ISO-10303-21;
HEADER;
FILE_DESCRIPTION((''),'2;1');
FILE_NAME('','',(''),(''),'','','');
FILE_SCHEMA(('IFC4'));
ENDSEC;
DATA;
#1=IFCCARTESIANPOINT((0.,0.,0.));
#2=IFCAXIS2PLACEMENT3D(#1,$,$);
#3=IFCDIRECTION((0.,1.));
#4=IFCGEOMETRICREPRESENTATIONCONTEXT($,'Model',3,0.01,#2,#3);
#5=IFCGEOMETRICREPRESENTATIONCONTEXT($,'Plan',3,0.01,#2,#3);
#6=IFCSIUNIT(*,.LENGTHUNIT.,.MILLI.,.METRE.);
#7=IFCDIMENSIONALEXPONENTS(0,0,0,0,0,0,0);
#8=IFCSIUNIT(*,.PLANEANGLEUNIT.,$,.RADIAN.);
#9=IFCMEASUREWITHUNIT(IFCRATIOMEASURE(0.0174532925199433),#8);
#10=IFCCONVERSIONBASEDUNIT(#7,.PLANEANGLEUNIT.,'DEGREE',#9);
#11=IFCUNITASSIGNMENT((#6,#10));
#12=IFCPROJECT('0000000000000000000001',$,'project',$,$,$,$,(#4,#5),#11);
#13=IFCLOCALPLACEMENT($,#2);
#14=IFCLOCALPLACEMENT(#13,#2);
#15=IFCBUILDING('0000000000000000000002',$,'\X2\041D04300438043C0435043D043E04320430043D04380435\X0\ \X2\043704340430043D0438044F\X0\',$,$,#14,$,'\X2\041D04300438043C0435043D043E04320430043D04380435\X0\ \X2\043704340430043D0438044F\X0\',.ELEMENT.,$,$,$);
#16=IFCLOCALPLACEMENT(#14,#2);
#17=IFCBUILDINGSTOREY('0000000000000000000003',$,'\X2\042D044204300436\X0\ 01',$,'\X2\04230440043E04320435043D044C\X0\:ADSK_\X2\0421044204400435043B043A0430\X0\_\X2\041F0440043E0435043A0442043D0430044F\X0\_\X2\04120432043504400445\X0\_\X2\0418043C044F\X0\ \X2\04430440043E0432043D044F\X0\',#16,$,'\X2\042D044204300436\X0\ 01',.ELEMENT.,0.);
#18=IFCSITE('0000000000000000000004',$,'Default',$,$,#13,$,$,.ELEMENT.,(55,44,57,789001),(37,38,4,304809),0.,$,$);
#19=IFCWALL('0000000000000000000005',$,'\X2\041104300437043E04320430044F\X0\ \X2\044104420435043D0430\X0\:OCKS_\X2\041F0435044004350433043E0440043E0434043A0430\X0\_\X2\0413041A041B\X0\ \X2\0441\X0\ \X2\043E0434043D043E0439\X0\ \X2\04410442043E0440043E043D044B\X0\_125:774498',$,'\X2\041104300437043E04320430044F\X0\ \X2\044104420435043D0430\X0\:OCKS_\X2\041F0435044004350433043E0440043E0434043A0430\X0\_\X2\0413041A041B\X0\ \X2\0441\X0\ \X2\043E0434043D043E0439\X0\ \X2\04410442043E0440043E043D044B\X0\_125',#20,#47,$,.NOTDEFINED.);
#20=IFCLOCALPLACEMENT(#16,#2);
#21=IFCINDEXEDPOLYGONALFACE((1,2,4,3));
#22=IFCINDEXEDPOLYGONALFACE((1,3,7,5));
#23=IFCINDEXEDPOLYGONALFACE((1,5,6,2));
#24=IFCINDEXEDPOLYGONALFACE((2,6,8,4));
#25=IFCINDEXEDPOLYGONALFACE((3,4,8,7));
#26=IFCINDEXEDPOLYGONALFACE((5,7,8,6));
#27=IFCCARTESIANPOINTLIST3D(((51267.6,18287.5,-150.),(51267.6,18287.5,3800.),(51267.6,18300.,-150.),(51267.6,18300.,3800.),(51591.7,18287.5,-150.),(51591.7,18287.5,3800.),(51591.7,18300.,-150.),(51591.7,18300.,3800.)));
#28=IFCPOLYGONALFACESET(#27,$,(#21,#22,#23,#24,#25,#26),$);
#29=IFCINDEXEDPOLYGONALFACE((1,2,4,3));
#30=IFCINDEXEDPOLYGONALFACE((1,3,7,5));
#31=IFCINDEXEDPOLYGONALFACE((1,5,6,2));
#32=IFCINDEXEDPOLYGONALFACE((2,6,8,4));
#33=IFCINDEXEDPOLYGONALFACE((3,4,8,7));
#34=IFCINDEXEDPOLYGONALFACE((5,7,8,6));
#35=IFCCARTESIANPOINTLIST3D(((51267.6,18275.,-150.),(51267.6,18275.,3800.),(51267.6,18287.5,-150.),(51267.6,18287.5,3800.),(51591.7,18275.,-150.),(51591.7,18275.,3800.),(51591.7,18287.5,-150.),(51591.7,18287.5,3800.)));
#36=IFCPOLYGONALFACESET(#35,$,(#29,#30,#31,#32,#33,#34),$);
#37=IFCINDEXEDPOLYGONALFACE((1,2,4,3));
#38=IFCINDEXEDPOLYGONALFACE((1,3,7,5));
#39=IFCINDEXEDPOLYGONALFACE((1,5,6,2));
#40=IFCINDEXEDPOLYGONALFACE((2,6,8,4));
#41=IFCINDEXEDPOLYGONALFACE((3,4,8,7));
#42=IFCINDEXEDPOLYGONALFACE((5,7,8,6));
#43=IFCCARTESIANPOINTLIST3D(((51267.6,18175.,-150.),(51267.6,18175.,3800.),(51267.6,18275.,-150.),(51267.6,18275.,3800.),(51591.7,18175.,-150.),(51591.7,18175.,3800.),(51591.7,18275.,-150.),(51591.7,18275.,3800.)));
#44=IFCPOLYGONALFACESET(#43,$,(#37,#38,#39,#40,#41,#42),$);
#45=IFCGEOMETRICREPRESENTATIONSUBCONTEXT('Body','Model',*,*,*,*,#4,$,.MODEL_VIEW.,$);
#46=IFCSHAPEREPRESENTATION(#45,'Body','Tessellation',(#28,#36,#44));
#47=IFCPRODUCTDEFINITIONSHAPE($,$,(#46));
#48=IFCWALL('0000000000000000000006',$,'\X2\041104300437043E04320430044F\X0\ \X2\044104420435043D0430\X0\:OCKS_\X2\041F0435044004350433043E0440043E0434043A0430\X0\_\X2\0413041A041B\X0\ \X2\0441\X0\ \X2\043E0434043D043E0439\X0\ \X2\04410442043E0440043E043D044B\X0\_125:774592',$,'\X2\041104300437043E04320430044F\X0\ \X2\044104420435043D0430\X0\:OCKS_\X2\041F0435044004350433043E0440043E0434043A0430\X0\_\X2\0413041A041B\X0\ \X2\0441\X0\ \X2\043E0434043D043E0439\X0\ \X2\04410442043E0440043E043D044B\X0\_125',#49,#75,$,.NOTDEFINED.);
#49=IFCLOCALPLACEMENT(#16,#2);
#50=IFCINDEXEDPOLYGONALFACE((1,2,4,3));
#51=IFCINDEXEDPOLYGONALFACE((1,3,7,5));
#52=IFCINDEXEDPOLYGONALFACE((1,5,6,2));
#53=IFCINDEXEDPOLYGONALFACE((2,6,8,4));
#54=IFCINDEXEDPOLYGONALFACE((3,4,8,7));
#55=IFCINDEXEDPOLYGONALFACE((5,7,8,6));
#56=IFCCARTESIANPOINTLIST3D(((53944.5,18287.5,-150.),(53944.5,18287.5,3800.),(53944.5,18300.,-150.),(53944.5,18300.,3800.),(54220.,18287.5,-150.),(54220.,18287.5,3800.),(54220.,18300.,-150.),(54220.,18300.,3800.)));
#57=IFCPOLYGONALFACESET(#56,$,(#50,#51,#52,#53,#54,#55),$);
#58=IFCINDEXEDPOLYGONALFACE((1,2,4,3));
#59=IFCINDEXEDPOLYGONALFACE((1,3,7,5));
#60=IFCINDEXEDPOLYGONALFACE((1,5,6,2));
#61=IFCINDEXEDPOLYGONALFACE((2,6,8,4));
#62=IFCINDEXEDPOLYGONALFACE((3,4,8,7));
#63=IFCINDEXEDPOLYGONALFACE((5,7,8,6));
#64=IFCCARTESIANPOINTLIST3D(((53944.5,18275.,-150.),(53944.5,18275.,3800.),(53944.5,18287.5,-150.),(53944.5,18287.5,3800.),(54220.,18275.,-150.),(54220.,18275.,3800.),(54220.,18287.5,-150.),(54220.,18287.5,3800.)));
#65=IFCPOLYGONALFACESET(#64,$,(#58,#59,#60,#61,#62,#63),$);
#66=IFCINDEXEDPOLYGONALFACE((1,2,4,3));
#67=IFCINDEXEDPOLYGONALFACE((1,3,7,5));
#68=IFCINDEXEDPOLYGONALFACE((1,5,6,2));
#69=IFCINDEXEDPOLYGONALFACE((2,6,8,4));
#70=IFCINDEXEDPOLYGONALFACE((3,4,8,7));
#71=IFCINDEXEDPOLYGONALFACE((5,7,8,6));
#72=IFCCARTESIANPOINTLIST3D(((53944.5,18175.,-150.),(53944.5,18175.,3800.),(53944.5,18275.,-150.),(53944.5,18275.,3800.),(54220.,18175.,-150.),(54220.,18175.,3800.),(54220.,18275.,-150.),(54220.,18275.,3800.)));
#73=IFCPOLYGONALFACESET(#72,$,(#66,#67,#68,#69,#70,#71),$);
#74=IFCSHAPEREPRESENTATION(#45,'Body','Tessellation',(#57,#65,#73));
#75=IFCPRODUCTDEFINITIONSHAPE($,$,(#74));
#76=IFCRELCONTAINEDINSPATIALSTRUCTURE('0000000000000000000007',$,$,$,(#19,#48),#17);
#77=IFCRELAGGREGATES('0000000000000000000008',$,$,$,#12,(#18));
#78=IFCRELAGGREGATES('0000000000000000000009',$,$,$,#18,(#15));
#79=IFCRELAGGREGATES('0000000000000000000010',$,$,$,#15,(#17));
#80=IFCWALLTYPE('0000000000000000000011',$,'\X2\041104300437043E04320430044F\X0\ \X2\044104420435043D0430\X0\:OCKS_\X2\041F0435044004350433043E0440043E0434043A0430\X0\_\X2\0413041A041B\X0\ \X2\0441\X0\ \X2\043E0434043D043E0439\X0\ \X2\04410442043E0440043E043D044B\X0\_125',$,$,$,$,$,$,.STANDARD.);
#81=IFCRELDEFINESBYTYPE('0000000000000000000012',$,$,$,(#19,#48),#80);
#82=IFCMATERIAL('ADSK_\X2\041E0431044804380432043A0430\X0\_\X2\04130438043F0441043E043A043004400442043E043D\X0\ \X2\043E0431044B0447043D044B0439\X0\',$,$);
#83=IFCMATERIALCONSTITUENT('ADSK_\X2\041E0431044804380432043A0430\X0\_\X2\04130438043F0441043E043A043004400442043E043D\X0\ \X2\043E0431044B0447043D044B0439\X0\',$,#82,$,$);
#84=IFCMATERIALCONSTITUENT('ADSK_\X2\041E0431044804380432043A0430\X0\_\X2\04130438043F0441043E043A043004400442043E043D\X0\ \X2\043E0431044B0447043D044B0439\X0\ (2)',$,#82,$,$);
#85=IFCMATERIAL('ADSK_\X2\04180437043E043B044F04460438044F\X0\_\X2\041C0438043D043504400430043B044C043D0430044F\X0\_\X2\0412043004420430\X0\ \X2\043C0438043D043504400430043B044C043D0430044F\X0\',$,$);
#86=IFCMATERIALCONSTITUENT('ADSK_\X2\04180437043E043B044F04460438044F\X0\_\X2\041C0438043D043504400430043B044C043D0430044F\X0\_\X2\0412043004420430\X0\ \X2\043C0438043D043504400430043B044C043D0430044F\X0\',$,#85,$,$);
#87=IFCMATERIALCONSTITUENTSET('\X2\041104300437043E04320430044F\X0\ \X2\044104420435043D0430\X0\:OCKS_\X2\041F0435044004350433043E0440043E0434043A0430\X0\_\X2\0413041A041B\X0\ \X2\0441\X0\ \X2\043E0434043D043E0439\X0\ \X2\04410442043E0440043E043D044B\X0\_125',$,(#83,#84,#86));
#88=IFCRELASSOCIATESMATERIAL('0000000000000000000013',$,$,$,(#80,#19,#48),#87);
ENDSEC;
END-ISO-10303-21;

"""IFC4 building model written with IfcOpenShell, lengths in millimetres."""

from ifc_helpers import new_model, entity, si_unit, converted_unit, direction, frame, origin, place, context, subcontext, project, spatial, indexed_curve, outline, extrude, material, constituent, constituent_set, type_object, element, save


model = new_model("IFC4")

# Units and contexts
model_context = context("Model", 3, precision=0.01, world=origin(), true_north=direction((0.0, 1.0)))
plan_context = context("Plan", 3, precision=0.01, world=origin(), true_north=direction((0.0, 1.0)))
body_context = subcontext(model_context, "Body", "Model", "MODEL_VIEW")
ifc_project = project(units=[si_unit("LENGTHUNIT", "METRE", prefix="MILLI"), converted_unit("PLANEANGLEUNIT", "DEGREE", entity("IfcRatioMeasure", 0.0174532925199433), si_unit("PLANEANGLEUNIT", "RADIAN"), dimensions=[0, 0, 0, 0, 0, 0, 0])], contexts=[model_context, plan_context])

# Site, building, storey
site_placement = place(None, frame((0.0, 0.0, 0.0)))
site = spatial("IfcSite", under=ifc_project, at=site_placement, Name="Default", CompositionType="ELEMENT", RefLatitude=(55, 44, 57, 789001), RefLongitude=(37, 38, 4, 304809), RefElevation=0.0)
building_placement = place(site_placement, origin())
building = spatial("IfcBuilding", under=site, at=building_placement, Name="Наименование здания", LongName="Наименование здания", CompositionType="ELEMENT")
storey_placement = place(building_placement, origin())
storey = spatial("IfcBuildingStorey", under=building, at=storey_placement, Name="Этаж 01", ObjectType="Уровень:ADSK_Стрелка_Проектная_Вверх_Имя уровня", LongName="Этаж 01", CompositionType="ELEMENT", Elevation=0.0)

# Shared definitions
ifc_material_1 = material(Name="ADSK_Обшивка_Гипсокартон обычный")
ifc_material_2 = material(Name="ADSK_Изоляция_Минеральная_Вата минеральная")

# Walls
ifc_constituent_1 = constituent(ifc_material_1, Name="ADSK_Обшивка_Гипсокартон обычный")
ifc_constituent_2 = constituent(ifc_material_1, Name="ADSK_Обшивка_Гипсокартон обычный (2)")
ifc_constituent_3 = constituent(ifc_material_2, Name="ADSK_Изоляция_Минеральная_Вата минеральная")
ifc_constituent_set_1 = constituent_set(constituents=[ifc_constituent_1, ifc_constituent_2, ifc_constituent_3], Name="Базовая стена:OCKS_Перегородка_ГКЛ с одной стороны_125")
wall_type_1 = type_object("IfcWallType", Name="Базовая стена:OCKS_Перегородка_ГКЛ с одной стороны_125", PredefinedType="STANDARD", material=ifc_constituent_set_1)
wall_1_placement = place(storey_placement, frame((51267.6, 18237.5, -150.0)))
element("IfcWall", 1, at=wall_1_placement, inside=storey, type_object=wall_type_1, material=ifc_constituent_set_1, Name="Базовая стена:OCKS_Перегородка_ГКЛ с одной стороны_125:774498", ObjectType="Базовая стена:OCKS_Перегородка_ГКЛ с одной стороны_125", PredefinedType="NOTDEFINED", context=body_context, shape_type="SweptSolid", body=[
    extrude(outline(indexed_curve([(-6.3, -162.0), (6.3, -162.0), (6.3, 162.0), (-6.2, 162.0), (-6.3, -162.0)], self_intersect=False)), frame((162.0, 56.3, 0.0), z_axis=(0.0, 0.0, 1.0), x_axis=(0.0, -1.0, 0.0)), (0.0, 0.0, 1.0), 3950.0),
    extrude(outline(indexed_curve([(-162.0, -6.2), (162.0, -6.2), (162.0, 6.3), (-162.0, 6.3), (-162.0, -6.2)], self_intersect=False)), frame((162.0, 43.7, 0.0)), (0.0, 0.0, 1.0), 3950.0),
    extrude(outline(indexed_curve([(-50.0, -162.0), (50.0, -162.0), (50.0, 162.0), (-50.0, 162.0), (-50.0, -162.0)], self_intersect=False)), frame((162.0, -12.5, 0.0), z_axis=(0.0, 0.0, 1.0), x_axis=(0.0, 1.0, 0.0)), (0.0, 0.0, 1.0), 3950.0),
])
wall_2_placement = place(storey_placement, frame((54220.0, 18237.5, -150.0), z_axis=(0.0, 0.0, 1.0), x_axis=(-1.0, 0.0, 0.0)))
element("IfcWall", 2, at=wall_2_placement, inside=storey, type_object=wall_type_1, material=ifc_constituent_set_1, Name="Базовая стена:OCKS_Перегородка_ГКЛ с одной стороны_125:774592", ObjectType="Базовая стена:OCKS_Перегородка_ГКЛ с одной стороны_125", PredefinedType="NOTDEFINED", context=body_context, shape_type="SweptSolid", body=[
    extrude(outline(indexed_curve([(-6.2, -137.7), (6.3, -137.7), (6.3, 137.7), (-6.2, 137.7), (-6.2, -137.7)], self_intersect=False)), frame((137.7, -56.3, 0.0), z_axis=(0.0, 0.0, 1.0), x_axis=(0.0, 1.0, 0.0)), (0.0, 0.0, 1.0), 3950.0),
    extrude(outline(indexed_curve([(-137.7, -6.3), (137.7, -6.3), (137.7, 6.2), (-137.7, 6.2), (-137.7, -6.3)], self_intersect=False)), frame((137.7, -43.7, 0.0)), (0.0, 0.0, 1.0), 3950.0),
    extrude(outline(indexed_curve([(-50.0, -137.7), (50.0, -137.7), (50.0, 137.7), (-50.0, 137.7), (-50.0, -137.7)], self_intersect=False)), frame((137.7, 12.5, 0.0), z_axis=(0.0, 0.0, 1.0), x_axis=(0.0, -1.0, 0.0)), (0.0, 0.0, 1.0), 3950.0),
])

save(model, "model.ifc")
